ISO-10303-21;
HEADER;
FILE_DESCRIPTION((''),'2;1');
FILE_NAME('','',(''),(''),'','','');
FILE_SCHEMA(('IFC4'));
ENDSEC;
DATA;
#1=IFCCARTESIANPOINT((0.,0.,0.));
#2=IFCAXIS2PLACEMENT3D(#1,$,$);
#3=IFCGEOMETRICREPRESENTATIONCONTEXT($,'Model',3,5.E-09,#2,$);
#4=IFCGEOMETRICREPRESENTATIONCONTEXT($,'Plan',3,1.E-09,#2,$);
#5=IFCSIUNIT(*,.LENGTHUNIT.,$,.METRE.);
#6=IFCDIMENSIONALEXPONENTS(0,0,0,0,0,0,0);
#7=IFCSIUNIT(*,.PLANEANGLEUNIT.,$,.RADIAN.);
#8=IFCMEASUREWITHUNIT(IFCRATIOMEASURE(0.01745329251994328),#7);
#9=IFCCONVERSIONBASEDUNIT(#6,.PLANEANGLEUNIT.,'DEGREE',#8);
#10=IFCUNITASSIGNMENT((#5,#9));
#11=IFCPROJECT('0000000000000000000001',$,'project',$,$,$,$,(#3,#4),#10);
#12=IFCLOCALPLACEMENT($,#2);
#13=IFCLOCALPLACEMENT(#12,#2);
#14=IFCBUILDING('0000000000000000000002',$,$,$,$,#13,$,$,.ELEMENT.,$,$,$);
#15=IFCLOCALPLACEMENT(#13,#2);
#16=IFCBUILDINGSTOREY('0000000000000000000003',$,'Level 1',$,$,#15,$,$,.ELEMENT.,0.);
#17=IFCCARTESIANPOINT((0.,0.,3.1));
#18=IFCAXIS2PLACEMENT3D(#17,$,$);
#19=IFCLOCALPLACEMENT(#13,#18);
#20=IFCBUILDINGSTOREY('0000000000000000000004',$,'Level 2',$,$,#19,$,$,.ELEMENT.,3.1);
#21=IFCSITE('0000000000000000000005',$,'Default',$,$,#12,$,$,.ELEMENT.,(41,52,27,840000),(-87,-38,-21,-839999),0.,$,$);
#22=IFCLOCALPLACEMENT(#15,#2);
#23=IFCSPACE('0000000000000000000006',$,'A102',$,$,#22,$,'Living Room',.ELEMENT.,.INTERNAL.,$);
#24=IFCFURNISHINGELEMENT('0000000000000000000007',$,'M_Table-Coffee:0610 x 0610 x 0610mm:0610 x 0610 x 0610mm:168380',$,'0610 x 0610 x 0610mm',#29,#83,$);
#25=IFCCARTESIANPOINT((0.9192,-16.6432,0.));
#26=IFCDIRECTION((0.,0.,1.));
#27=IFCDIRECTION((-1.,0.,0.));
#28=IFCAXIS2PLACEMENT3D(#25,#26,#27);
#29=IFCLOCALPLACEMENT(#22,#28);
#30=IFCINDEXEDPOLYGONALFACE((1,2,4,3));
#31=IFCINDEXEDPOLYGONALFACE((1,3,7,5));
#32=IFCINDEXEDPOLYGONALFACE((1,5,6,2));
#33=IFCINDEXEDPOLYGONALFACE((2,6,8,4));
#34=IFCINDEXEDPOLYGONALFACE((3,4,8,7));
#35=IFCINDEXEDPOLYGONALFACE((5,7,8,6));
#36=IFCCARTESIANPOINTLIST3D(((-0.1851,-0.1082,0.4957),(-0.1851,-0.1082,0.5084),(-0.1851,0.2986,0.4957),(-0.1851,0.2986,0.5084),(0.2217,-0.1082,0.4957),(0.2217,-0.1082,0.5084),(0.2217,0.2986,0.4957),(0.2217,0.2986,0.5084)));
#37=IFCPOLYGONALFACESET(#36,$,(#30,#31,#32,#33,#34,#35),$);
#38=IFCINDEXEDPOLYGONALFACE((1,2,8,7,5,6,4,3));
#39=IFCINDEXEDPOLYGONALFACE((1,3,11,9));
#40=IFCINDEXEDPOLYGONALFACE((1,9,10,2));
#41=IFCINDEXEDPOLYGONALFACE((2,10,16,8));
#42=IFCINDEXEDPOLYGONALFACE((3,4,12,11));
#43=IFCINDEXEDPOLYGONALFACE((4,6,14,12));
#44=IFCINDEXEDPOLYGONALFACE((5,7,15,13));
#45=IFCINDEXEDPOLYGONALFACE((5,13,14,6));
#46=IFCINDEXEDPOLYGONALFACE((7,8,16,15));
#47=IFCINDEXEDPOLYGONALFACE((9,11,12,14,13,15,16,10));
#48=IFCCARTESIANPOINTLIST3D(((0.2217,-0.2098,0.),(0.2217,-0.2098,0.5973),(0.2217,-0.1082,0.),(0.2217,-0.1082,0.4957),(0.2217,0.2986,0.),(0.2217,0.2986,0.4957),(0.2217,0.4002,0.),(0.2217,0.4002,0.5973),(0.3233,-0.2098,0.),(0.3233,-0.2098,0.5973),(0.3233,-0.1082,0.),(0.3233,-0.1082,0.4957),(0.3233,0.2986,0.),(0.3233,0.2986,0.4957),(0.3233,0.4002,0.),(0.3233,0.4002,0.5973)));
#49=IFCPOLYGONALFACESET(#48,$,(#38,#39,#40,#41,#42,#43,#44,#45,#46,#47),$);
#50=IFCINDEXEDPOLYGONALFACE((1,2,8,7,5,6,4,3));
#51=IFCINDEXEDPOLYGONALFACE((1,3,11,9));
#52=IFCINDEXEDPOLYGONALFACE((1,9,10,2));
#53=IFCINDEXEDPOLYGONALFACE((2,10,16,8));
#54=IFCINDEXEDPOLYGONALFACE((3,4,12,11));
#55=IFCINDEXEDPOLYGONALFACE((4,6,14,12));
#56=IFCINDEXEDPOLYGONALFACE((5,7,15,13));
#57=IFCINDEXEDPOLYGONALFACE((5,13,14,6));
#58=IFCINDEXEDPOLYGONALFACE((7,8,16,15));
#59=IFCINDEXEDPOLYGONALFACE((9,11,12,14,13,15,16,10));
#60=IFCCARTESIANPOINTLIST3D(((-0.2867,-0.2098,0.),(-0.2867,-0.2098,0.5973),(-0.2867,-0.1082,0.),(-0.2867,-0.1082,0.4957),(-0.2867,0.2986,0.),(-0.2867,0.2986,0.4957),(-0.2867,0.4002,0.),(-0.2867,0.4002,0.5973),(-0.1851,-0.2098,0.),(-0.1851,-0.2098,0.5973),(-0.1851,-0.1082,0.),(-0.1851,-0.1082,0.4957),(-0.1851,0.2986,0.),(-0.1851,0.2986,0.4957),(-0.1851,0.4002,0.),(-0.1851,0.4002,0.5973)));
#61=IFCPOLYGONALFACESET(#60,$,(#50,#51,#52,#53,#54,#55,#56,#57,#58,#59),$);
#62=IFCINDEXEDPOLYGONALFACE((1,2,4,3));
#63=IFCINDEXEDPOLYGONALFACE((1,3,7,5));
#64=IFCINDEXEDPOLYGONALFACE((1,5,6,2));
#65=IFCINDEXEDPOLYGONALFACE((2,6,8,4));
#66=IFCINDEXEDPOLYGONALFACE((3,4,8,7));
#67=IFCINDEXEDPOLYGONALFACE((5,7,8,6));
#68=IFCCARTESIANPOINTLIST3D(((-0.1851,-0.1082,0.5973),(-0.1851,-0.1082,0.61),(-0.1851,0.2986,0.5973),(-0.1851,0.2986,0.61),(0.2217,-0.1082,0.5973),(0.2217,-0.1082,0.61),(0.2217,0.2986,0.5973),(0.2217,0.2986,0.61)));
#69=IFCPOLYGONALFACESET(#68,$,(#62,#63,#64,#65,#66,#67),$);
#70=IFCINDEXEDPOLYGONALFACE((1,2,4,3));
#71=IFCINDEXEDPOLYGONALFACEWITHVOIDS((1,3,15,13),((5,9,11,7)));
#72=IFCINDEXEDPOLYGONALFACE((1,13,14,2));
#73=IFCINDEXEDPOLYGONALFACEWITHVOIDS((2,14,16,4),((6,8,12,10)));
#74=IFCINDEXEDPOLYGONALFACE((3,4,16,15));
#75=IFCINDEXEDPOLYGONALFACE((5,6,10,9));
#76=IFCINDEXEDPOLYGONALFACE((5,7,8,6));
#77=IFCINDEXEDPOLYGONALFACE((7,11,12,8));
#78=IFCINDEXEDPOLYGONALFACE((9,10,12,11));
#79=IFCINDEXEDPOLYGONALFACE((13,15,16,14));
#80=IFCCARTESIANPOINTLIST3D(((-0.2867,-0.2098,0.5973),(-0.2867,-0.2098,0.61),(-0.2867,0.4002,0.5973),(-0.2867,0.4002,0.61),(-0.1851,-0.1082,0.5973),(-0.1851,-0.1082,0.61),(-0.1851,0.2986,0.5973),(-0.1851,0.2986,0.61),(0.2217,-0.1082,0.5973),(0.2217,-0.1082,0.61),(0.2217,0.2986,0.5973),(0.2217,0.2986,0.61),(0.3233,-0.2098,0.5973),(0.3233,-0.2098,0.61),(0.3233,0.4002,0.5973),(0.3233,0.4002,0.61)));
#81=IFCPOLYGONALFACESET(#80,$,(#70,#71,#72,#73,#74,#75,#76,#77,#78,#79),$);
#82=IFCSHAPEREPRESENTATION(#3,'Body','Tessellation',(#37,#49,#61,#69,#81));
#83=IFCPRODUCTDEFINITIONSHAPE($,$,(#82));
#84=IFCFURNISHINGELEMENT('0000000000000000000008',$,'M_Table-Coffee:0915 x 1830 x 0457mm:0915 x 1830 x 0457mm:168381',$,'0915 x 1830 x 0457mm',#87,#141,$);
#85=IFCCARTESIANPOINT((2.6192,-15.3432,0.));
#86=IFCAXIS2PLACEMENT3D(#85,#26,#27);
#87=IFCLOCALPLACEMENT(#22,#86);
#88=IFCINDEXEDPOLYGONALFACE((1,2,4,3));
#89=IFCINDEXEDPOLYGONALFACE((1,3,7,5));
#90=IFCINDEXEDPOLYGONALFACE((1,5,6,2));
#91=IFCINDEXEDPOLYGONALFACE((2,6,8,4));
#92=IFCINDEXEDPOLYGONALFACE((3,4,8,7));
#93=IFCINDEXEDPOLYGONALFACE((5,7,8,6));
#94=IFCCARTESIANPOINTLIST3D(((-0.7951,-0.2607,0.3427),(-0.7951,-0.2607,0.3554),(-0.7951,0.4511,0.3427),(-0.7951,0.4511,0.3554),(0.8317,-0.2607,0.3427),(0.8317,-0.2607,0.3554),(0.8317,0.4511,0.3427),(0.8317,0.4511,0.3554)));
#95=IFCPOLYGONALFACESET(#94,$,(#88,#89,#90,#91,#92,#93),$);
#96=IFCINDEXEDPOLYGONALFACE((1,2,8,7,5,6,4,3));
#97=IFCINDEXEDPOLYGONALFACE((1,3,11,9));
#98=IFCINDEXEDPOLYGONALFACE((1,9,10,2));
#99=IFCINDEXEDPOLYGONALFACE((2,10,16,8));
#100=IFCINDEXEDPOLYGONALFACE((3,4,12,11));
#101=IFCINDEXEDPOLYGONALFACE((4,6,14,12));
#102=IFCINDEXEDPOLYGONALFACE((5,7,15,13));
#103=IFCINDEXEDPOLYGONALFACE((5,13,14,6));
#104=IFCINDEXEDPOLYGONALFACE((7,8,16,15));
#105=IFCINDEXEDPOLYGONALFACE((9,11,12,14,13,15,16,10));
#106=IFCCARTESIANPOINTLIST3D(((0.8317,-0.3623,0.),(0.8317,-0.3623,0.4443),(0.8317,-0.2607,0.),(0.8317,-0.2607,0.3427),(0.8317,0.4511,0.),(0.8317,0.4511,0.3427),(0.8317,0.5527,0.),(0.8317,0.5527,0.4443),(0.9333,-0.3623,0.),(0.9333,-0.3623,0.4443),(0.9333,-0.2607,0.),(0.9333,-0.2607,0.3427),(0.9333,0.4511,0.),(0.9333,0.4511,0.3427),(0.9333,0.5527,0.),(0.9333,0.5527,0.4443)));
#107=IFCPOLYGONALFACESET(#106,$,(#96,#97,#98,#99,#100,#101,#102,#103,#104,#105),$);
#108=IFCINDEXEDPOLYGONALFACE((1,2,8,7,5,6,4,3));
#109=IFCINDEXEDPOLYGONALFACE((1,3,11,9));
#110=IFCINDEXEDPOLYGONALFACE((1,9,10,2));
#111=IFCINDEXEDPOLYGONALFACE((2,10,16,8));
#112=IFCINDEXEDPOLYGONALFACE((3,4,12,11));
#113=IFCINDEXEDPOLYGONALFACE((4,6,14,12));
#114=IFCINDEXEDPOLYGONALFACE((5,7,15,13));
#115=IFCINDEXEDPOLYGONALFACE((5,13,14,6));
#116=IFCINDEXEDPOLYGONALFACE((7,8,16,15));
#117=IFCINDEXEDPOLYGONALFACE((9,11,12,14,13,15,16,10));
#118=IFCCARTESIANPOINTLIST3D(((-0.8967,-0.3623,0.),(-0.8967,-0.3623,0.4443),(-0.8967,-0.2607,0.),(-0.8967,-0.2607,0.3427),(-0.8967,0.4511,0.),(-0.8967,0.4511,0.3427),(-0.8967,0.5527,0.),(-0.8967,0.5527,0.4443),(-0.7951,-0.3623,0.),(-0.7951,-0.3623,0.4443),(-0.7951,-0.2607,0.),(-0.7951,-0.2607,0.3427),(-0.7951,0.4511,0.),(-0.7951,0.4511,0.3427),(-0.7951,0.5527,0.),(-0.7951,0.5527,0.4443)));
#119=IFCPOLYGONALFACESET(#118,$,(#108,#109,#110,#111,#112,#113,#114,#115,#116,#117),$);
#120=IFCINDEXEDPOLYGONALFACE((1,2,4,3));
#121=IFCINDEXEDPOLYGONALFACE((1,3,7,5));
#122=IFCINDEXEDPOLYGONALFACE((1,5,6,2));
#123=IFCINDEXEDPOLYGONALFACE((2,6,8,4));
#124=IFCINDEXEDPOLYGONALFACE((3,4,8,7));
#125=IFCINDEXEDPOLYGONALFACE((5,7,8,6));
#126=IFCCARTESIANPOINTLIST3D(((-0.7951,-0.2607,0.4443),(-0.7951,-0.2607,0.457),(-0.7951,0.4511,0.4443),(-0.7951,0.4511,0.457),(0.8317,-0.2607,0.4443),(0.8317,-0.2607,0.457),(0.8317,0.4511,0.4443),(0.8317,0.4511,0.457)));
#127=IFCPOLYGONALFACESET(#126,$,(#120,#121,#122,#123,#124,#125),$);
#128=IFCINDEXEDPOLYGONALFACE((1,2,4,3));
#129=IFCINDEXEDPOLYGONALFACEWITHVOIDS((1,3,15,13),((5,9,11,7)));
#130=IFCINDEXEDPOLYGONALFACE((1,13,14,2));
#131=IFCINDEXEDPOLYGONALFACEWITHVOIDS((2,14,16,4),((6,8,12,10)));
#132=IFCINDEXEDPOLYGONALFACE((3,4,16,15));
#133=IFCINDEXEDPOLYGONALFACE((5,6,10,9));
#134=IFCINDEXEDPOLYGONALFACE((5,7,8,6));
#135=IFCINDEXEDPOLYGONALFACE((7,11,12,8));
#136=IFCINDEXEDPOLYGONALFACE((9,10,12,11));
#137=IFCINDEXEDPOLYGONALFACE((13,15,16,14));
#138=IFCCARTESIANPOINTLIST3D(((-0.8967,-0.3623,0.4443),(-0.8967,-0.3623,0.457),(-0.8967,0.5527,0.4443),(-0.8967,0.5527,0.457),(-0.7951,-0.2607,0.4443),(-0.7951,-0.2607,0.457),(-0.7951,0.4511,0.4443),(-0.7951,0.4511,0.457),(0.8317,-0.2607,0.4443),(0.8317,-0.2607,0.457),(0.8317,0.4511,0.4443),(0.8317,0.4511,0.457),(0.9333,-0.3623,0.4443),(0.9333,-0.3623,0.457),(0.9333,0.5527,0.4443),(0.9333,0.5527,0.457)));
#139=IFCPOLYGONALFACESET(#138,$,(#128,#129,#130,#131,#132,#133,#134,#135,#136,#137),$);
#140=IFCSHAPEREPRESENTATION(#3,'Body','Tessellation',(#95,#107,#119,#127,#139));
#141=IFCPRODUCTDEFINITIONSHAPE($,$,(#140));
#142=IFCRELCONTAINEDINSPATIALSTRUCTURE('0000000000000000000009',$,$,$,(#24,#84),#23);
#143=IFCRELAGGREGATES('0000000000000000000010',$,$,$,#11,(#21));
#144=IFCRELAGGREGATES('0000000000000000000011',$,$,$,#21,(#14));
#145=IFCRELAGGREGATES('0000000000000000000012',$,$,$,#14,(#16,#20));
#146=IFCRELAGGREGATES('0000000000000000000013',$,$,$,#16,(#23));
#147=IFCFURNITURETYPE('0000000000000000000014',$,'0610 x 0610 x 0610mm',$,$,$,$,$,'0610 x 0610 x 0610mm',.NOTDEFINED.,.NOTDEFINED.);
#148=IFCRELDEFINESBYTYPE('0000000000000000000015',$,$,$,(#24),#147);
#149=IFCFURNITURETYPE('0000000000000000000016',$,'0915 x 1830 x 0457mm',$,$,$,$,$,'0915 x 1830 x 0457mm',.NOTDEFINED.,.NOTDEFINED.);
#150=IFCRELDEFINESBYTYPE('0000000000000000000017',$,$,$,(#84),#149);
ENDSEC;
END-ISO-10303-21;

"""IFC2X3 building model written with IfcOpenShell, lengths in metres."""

from ifc_helpers import new_model, entity, si_unit, converted_unit, frame, origin, origin_2d_with_axis, place, context, project, spatial, polyline, rectangle, outline, extrude, source, transform, mapped, type_object, type_shapes, element, save


model = new_model("IFC2X3")

# Units and contexts
model_context = context("Model", 3, precision=5e-09, world=origin())
plan_context = context("Plan", 3, precision=1e-09, world=origin())
ifc_project = project(units=[si_unit("LENGTHUNIT", "METRE"), converted_unit("PLANEANGLEUNIT", "DEGREE", entity("IfcRatioMeasure", 0.01745329251994328), si_unit("PLANEANGLEUNIT", "RADIAN"), dimensions=[0, 0, 0, 0, 0, 0, 0])], contexts=[model_context, plan_context])

# Site, building, storey
site_placement = place(None, origin())
site = spatial("IfcSite", under=ifc_project, at=site_placement, Name="Default", CompositionType="ELEMENT", RefLatitude=(41, 52, 27, 840000), RefLongitude=(-87, -38, -21, -839999), RefElevation=0.0)
building_placement = place(site_placement, origin())
building = spatial("IfcBuilding", under=site, at=building_placement, CompositionType="ELEMENT")
storey_1_placement = place(building_placement, origin())
storey_1 = spatial("IfcBuildingStorey", under=building, at=storey_1_placement, Name="Level 1", CompositionType="ELEMENT", Elevation=0.0)

# Shared definitions
storey_2_placement = place(building_placement, frame((0.0, 0.0, 3.1)))
storey_2 = spatial("IfcBuildingStorey", under=building, at=storey_2_placement, Name="Level 2", CompositionType="ELEMENT", Elevation=3.1)

# Shared definitions
space_1_placement = place(storey_1_placement, origin())
space_1 = spatial("IfcSpace", under=storey_1, at=space_1_placement, Name="A102", LongName="Living Room", CompositionType="ELEMENT", InteriorOrExteriorSpace="INTERNAL")

# Furnishing element
furniture_type_1 = type_object("IfcFurnitureType", Name="0610 x 0610 x 0610mm", ElementType="0610 x 0610 x 0610mm", AssemblyPlace="NOTDEFINED")
shared_shape_1 = source(origin(), model_context, "Body", "SweptSolid", [
    extrude(rectangle(XDim=0.4068, YDim=0.4068, at=origin_2d_with_axis()), frame((0.0183, 0.0952, 0.4957), z_axis=(0.0, 0.0, 1.0), x_axis=(-1.0, 0.0, 0.0)), (0.0, 0.0, 1.0), 0.0127),
    extrude(outline(polyline([(-0.2732, -0.305), (0.324, -0.305), (0.324, 0.305), (-0.2732, 0.305), (-0.2732, 0.2034), (0.2225, 0.2034), (0.2225, -0.2034), (-0.2732, -0.2034), (-0.2732, -0.305)])), frame((0.2217, 0.0952, 0.2732), z_axis=(1.0, 0.0, 0.0), x_axis=(0.0, 0.0, 1.0)), (0.0, 0.0, 1.0), 0.1016),
    extrude(outline(polyline([(-0.305, -0.3241), (0.305, -0.3241), (0.305, 0.2733), (0.2034, 0.2733), (0.2034, -0.2224), (-0.2034, -0.2224), (-0.2034, 0.2733), (-0.305, 0.2733), (-0.305, -0.3241)])), frame((-0.2867, 0.0952, 0.2733), z_axis=(1.0, 0.0, 0.0), x_axis=(0.0, -1.0, 0.0)), (0.0, 0.0, 1.0), 0.1016),
    extrude(rectangle(XDim=0.4068, YDim=0.4068, at=origin_2d_with_axis()), frame((0.0183, 0.0952, 0.5973), z_axis=(0.0, 0.0, 1.0), x_axis=(-1.0, 0.0, 0.0)), (0.0, 0.0, 1.0), 0.0127),
    extrude(outline(polyline([(-0.305, -0.305), (0.305, -0.305), (0.305, 0.305), (-0.305, 0.305), (-0.305, -0.305)]), holes=[polyline([(-0.2034, -0.2034), (-0.2034, 0.2034), (0.2034, 0.2034), (0.2034, -0.2034), (-0.2034, -0.2034)])]), frame((0.0183, 0.0952, 0.5973), z_axis=(0.0, 0.0, 1.0), x_axis=(-1.0, 0.0, 0.0)), (0.0, 0.0, 1.0), 0.0127),
])
type_shapes(furniture_type_1, [shared_shape_1])
for number, where, z_axis, x_axis, name in (
    (1, (0.9192, -16.6432, 0.0), (0.0, 0.0, 1.0), (-1.0, 0.0, 0.0), "M_Table-Coffee:0610 x 0610 x 0610mm:0610 x 0610 x 0610mm:168380"),
):
    element("IfcFurnishingElement", number, at=place(space_1_placement, frame(where, z_axis=z_axis, x_axis=x_axis)), inside=space_1, type_object=furniture_type_1, Name=name, ObjectType="0610 x 0610 x 0610mm", context=model_context, shape_type="MappedRepresentation", body=[
        mapped(shared_shape_1, transform((0.0, 0.0, 0.0), scale=1.0)),
    ])

# Furnishing element
furniture_type_2 = type_object("IfcFurnitureType", Name="0915 x 1830 x 0457mm", ElementType="0915 x 1830 x 0457mm", AssemblyPlace="NOTDEFINED")
shared_shape_2 = source(origin(), model_context, "Body", "SweptSolid", [
    extrude(rectangle(XDim=1.6268, YDim=0.7118, at=origin_2d_with_axis()), frame((0.0183, 0.0952, 0.3427), z_axis=(0.0, 0.0, 1.0), x_axis=(-1.0, 0.0, 0.0)), (0.0, 0.0, 1.0), 0.0127),
    extrude(outline(polyline([(-0.1967, -0.4575), (0.2475, -0.4575), (0.2475, 0.4575), (-0.1967, 0.4575), (-0.1967, 0.3559), (0.146, 0.3559), (0.146, -0.3559), (-0.1967, -0.3559), (-0.1967, -0.4575)])), frame((0.8317, 0.0952, 0.1967), z_axis=(1.0, 0.0, 0.0), x_axis=(0.0, 0.0, 1.0)), (0.0, 0.0, 1.0), 0.1016),
    extrude(outline(polyline([(-0.4575, -0.2476), (0.4575, -0.2476), (0.4575, 0.1968), (0.3559, 0.1968), (0.3559, -0.1459), (-0.3559, -0.1459), (-0.3559, 0.1968), (-0.4575, 0.1968), (-0.4575, -0.2476)])), frame((-0.8967, 0.0952, 0.1968), z_axis=(1.0, 0.0, 0.0), x_axis=(0.0, -1.0, 0.0)), (0.0, 0.0, 1.0), 0.1016),
    extrude(rectangle(XDim=1.6268, YDim=0.7118, at=origin_2d_with_axis()), frame((0.0183, 0.0952, 0.4443), z_axis=(0.0, 0.0, 1.0), x_axis=(-1.0, 0.0, 0.0)), (0.0, 0.0, 1.0), 0.0127),
    extrude(outline(polyline([(-0.915, -0.4575), (0.915, -0.4575), (0.915, 0.4575), (-0.915, 0.4575), (-0.915, -0.4575)]), holes=[polyline([(-0.8134, -0.3559), (-0.8134, 0.3559), (0.8134, 0.3559), (0.8134, -0.3559), (-0.8134, -0.3559)])]), frame((0.0183, 0.0952, 0.4443), z_axis=(0.0, 0.0, 1.0), x_axis=(-1.0, 0.0, 0.0)), (0.0, 0.0, 1.0), 0.0127),
])
type_shapes(furniture_type_2, [shared_shape_2])
furnishing_1_placement = place(space_1_placement, frame((2.6192, -15.3432, 0.0), z_axis=(0.0, 0.0, 1.0), x_axis=(-1.0, 0.0, 0.0)))
element("IfcFurnishingElement", 2, at=furnishing_1_placement, inside=space_1, type_object=furniture_type_2, Name="M_Table-Coffee:0915 x 1830 x 0457mm:0915 x 1830 x 0457mm:168381", ObjectType="0915 x 1830 x 0457mm", context=model_context, shape_type="MappedRepresentation", body=[
    mapped(shared_shape_2, transform((0.0, 0.0, 0.0), scale=1.0)),
])

save(model, "model.ifc")
